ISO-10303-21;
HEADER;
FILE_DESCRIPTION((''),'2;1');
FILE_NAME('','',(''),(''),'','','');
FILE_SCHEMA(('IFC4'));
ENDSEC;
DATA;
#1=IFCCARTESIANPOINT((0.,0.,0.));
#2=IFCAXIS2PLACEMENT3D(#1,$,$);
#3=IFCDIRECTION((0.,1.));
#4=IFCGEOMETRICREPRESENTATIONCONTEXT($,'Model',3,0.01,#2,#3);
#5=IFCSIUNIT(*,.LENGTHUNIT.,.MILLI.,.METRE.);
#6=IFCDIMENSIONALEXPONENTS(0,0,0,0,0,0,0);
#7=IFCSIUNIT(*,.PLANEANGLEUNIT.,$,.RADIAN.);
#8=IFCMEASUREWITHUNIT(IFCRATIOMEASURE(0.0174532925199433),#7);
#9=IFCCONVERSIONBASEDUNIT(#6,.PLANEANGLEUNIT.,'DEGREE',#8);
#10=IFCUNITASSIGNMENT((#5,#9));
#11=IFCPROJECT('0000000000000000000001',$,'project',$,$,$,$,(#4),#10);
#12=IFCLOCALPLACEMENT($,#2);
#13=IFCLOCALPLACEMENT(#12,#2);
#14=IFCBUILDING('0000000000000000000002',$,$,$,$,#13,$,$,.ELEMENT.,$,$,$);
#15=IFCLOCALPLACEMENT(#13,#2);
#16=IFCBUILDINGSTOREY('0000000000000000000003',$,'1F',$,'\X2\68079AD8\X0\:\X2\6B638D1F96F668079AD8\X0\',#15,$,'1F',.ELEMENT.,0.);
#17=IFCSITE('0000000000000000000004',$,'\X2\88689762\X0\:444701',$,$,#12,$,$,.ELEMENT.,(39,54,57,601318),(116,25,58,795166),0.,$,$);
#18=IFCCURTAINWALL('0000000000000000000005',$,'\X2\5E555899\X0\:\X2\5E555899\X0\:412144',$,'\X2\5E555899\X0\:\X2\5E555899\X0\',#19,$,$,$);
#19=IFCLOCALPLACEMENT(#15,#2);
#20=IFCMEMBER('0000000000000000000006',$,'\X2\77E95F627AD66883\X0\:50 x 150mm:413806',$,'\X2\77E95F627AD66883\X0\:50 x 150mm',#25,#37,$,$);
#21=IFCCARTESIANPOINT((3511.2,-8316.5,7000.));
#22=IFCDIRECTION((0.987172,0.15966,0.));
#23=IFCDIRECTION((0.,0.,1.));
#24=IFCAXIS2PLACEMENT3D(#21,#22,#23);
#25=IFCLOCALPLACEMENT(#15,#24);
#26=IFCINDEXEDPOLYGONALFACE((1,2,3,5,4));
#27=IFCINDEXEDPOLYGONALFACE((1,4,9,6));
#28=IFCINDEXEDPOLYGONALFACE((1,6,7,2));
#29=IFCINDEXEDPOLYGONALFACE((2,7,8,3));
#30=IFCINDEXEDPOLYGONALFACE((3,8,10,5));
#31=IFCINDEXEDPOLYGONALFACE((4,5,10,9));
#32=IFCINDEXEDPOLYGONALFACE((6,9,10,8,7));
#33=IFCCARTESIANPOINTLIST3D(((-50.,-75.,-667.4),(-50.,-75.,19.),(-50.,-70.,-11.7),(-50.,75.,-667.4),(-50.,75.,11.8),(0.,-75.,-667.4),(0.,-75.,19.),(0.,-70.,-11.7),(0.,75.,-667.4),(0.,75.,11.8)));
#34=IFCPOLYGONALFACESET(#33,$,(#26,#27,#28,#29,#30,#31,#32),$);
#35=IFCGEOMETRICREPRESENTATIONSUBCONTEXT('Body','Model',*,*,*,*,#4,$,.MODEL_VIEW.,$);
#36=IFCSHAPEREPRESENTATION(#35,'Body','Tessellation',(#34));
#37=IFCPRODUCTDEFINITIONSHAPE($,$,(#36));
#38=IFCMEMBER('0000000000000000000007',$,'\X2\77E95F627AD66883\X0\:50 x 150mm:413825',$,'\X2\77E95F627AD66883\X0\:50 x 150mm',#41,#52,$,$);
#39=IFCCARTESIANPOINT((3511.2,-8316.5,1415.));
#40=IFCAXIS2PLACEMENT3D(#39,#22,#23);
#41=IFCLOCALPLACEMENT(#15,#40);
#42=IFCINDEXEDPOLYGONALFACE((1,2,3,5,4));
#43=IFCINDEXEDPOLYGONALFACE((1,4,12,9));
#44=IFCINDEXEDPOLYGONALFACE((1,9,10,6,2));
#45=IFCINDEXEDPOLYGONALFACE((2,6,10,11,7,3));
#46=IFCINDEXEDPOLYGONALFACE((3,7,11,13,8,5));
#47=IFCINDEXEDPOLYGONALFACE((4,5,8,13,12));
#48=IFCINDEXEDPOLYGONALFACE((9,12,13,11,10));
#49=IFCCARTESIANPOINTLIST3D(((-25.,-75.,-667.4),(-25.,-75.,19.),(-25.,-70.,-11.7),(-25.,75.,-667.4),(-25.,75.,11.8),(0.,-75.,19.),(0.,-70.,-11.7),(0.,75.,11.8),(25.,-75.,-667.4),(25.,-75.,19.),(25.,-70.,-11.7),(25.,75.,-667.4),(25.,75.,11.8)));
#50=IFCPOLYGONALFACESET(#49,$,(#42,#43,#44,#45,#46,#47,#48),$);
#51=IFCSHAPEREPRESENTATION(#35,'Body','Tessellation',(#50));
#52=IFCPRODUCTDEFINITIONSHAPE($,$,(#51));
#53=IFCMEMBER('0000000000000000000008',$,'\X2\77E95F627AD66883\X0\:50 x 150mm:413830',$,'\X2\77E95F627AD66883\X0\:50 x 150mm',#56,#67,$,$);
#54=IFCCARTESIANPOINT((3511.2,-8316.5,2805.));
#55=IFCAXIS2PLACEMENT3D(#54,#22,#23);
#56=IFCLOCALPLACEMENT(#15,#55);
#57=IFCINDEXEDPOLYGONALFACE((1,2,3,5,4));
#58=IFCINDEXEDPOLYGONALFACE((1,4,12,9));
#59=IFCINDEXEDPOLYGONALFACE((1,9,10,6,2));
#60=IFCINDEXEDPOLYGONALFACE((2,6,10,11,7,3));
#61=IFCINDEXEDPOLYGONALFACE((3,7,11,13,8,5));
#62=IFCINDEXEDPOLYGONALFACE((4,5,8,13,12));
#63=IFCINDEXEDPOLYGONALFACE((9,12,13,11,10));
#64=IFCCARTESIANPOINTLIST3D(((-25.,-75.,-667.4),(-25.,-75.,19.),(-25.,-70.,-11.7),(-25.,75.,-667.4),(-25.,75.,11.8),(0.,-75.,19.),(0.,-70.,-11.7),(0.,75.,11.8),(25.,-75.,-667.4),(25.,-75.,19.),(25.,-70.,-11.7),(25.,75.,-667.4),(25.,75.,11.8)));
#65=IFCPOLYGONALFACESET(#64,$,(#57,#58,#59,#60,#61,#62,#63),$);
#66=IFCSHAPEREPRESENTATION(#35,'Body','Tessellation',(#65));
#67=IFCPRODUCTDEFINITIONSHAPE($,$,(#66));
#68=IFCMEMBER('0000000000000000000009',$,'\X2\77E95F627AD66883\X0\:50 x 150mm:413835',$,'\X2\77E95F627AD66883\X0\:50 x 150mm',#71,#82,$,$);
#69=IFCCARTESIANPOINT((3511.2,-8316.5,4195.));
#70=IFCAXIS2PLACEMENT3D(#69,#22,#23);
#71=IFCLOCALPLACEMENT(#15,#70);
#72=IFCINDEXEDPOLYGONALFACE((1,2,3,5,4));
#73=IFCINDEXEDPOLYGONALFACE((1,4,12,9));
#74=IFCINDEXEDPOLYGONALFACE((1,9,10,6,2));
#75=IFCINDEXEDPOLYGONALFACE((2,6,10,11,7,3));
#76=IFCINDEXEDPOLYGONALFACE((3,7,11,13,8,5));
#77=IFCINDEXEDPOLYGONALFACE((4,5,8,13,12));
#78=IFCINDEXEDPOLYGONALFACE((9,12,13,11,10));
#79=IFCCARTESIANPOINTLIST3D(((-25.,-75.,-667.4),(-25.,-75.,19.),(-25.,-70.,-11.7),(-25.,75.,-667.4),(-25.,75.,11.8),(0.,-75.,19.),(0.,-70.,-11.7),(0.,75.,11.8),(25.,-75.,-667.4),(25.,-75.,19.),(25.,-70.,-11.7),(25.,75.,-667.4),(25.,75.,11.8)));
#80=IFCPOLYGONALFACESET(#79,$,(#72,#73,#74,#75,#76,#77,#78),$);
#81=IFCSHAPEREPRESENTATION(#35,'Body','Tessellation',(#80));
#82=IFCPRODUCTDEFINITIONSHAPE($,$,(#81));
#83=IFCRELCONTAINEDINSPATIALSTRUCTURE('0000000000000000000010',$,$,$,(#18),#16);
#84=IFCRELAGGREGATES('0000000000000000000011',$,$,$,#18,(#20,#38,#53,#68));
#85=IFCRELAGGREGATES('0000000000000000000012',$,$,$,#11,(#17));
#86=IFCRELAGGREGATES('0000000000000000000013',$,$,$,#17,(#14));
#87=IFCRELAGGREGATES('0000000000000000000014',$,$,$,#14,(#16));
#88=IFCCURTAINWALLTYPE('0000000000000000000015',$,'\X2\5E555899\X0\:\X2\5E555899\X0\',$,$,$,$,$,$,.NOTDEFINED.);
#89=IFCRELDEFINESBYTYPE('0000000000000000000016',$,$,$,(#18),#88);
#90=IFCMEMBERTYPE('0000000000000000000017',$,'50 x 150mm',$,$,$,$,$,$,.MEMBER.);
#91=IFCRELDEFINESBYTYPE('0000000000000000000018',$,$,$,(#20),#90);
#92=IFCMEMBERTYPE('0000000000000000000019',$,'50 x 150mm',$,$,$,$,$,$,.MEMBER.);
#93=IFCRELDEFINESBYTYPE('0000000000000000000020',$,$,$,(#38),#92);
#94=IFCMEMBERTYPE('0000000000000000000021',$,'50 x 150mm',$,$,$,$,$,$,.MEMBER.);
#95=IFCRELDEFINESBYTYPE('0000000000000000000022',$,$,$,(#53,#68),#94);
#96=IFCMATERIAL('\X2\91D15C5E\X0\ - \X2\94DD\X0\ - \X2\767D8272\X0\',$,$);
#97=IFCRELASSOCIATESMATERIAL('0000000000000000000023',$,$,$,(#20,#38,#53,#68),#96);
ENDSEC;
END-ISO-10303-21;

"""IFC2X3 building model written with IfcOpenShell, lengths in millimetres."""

from ifc_helpers import new_model, entity, si_unit, converted_unit, direction, frame, origin, origin_2d_with_axis, place, context, subcontext, project, spatial, polyline, rectangle, extrude, clip, bounded_halfspace, source, transform, mapped, material, type_object, type_shapes, element, aggregate, save


model = new_model("IFC2X3")

# Units and contexts
model_context = context("Model", 3, precision=0.01, world=origin(), true_north=direction((0.0, 1.0)))
body_context = subcontext(model_context, "Body", "Model", "MODEL_VIEW")
ifc_project = project(units=[si_unit("LENGTHUNIT", "METRE", prefix="MILLI"), converted_unit("PLANEANGLEUNIT", "DEGREE", entity("IfcRatioMeasure", 0.0174532925199433), si_unit("PLANEANGLEUNIT", "RADIAN"), dimensions=[0, 0, 0, 0, 0, 0, 0])], contexts=[model_context])

# Site, building, storey
site_placement = place(None, origin())
site = spatial("IfcSite", under=ifc_project, at=site_placement, Name="表面:444701", CompositionType="ELEMENT", RefLatitude=(39, 54, 57, 601318), RefLongitude=(116, 25, 58, 795166), RefElevation=0.0)
building_placement = place(site_placement, origin())
building = spatial("IfcBuilding", under=site, at=building_placement, CompositionType="ELEMENT")
storey_placement = place(building_placement, origin())
storey = spatial("IfcBuildingStorey", under=building, at=storey_placement, Name="1F", ObjectType="标高:正负零标高", LongName="1F", CompositionType="ELEMENT", Elevation=0.0)

# Curtain wall, members
curtain_wall_type = type_object("IfcCurtainWallType", Name="幕墙:幕墙", PredefinedType="NOTDEFINED")
curtain_wall_1_placement = place(storey_placement, origin())
curtain_wall_1 = element("IfcCurtainWall", 1, at=curtain_wall_1_placement, inside=storey, type_object=curtain_wall_type, Name="幕墙:幕墙:412144", ObjectType="幕墙:幕墙")
ifc_material_1 = material(Name="金属 - 铝 - 白色")
member_type_1 = type_object("IfcMemberType", Name="50 x 150mm", PredefinedType="MEMBER")
shared_shape_1 = source(origin(), body_context, "Body", "Clipping", [
    clip(clip(extrude(rectangle(XDim=50.0, YDim=150.0, at=origin_2d_with_axis()), frame((-25.0, 0.0, -667.4)), (0.0, 0.0, 1.0), 686.4), bounded_halfspace(frame((-1415.0, -70.0, -11.7), z_axis=(0.0, 0.987172, 0.15966), x_axis=(1.0, 0.0, 0.0)), False, frame((-25.0, 0.0, -667.4)), polyline([(-25.0, -70.0), (-25.0, -75.0), (25.0, -75.0), (25.0, -70.0), (-25.0, -70.0)]))), bounded_halfspace(frame((-1415.0, 78.0, 12.3), z_axis=(0.0, -0.15966, 0.987172), x_axis=(1.0, 0.0, 0.0)), False, frame((-25.0, 0.0, -667.4)), polyline([(25.0, 75.0), (-25.0, 75.0), (-25.0, -70.0), (25.0, -70.0), (25.0, 75.0)]))),
])
type_shapes(member_type_1, [shared_shape_1])
member_1_placement = place(storey_placement, frame((3511.2, -8316.5, 7000.0), z_axis=(0.987172, 0.15966, 0.0), x_axis=(0.0, 0.0, 1.0)))
member_1 = element("IfcMember", 2, at=member_1_placement, type_object=member_type_1, material=ifc_material_1, Name="矩形竖梃:50 x 150mm:413806", ObjectType="矩形竖梃:50 x 150mm", context=body_context, shape_type="MappedRepresentation", body=[
    mapped(shared_shape_1, transform((0.0, 0.0, 0.0), scale=1.0)),
])
member_type_2 = type_object("IfcMemberType", Name="50 x 150mm", PredefinedType="MEMBER")
shared_shape_2 = source(origin(), body_context, "Body", "Clipping", [
    clip(clip(clip(clip(extrude(rectangle(XDim=150.0, YDim=50.0, at=origin_2d_with_axis()), frame((0.0, 0.0, -667.4), z_axis=(0.0, 0.0, 1.0), x_axis=(0.0, -1.0, 0.0)), (0.0, 0.0, 1.0), 686.4), bounded_halfspace(frame((-1415.0, -70.0, -11.7), z_axis=(0.0, 0.987172, 0.15966), x_axis=(1.0, 0.0, 0.0)), False, frame((0.0, 0.0, -667.4), z_axis=(0.0, 0.0, 1.0), x_axis=(0.0, -1.0, 0.0)), polyline([(70.0, -25.0), (75.0, -25.0), (75.0, 0.0), (70.0, 0.0), (70.0, -25.0)]))), bounded_halfspace(frame((0.0, -70.0, -11.7), z_axis=(0.0, 0.987172, 0.15966), x_axis=(1.0, 0.0, 0.0)), False, frame((0.0, 0.0, -667.4), z_axis=(0.0, 0.0, 1.0), x_axis=(0.0, -1.0, 0.0)), polyline([(75.0, 0.0), (75.0, 25.0), (70.0, 25.0), (70.0, 0.0), (75.0, 0.0)]))), bounded_halfspace(frame((-1415.0, 78.0, 12.3), z_axis=(0.0, -0.15966, 0.987172), x_axis=(1.0, 0.0, 0.0)), False, frame((0.0, 0.0, -667.4), z_axis=(0.0, 0.0, 1.0), x_axis=(0.0, -1.0, 0.0)), polyline([(-75.0, 0.0), (-75.0, -25.0), (70.0, -25.0), (70.0, 0.0), (-75.0, 0.0)]))), bounded_halfspace(frame((0.0, 78.0, 12.3), z_axis=(0.0, -0.15966, 0.987172), x_axis=(1.0, 0.0, 0.0)), False, frame((0.0, 0.0, -667.4), z_axis=(0.0, 0.0, 1.0), x_axis=(0.0, -1.0, 0.0)), polyline([(-75.0, 25.0), (-75.0, 0.0), (70.0, 0.0), (70.0, 25.0), (-75.0, 25.0)]))),
])
type_shapes(member_type_2, [shared_shape_2])
member_2_placement = place(storey_placement, frame((3511.2, -8316.5, 1415.0), z_axis=(0.987172, 0.15966, 0.0), x_axis=(0.0, 0.0, 1.0)))
member_2 = element("IfcMember", 3, at=member_2_placement, type_object=member_type_2, material=ifc_material_1, Name="矩形竖梃:50 x 150mm:413825", ObjectType="矩形竖梃:50 x 150mm", context=body_context, shape_type="MappedRepresentation", body=[
    mapped(shared_shape_2, transform((0.0, 0.0, 0.0), scale=1.0)),
])
member_type_3 = type_object("IfcMemberType", Name="50 x 150mm", PredefinedType="MEMBER")
shared_shape_3 = source(origin(), body_context, "Body", "Clipping", [
    clip(clip(clip(clip(extrude(rectangle(XDim=150.0, YDim=50.0, at=origin_2d_with_axis()), frame((0.0, 0.0, -667.4), z_axis=(0.0, 0.0, 1.0), x_axis=(0.0, -1.0, 0.0)), (0.0, 0.0, 1.0), 686.4), bounded_halfspace(frame((-1390.0, -70.0, -11.7), z_axis=(0.0, 0.987172, 0.15966), x_axis=(1.0, 0.0, 0.0)), False, frame((0.0, 0.0, -667.4), z_axis=(0.0, 0.0, 1.0), x_axis=(0.0, -1.0, 0.0)), polyline([(70.0, -25.0), (75.0, -25.0), (75.0, 0.0), (70.0, 0.0), (70.0, -25.0)]))), bounded_halfspace(frame((0.0, -70.0, -11.7), z_axis=(0.0, 0.987172, 0.15966), x_axis=(1.0, 0.0, 0.0)), False, frame((0.0, 0.0, -667.4), z_axis=(0.0, 0.0, 1.0), x_axis=(0.0, -1.0, 0.0)), polyline([(75.0, 0.0), (75.0, 25.0), (70.0, 25.0), (70.0, 0.0), (75.0, 0.0)]))), bounded_halfspace(frame((-1390.0, 78.0, 12.3), z_axis=(0.0, -0.15966, 0.987172), x_axis=(1.0, 0.0, 0.0)), False, frame((0.0, 0.0, -667.4), z_axis=(0.0, 0.0, 1.0), x_axis=(0.0, -1.0, 0.0)), polyline([(-75.0, 0.0), (-75.0, -25.0), (70.0, -25.0), (70.0, 0.0), (-75.0, 0.0)]))), bounded_halfspace(frame((0.0, 78.0, 12.3), z_axis=(0.0, -0.15966, 0.987172), x_axis=(1.0, 0.0, 0.0)), False, frame((0.0, 0.0, -667.4), z_axis=(0.0, 0.0, 1.0), x_axis=(0.0, -1.0, 0.0)), polyline([(-75.0, 25.0), (-75.0, 0.0), (70.0, 0.0), (70.0, 25.0), (-75.0, 25.0)]))),
])
type_shapes(member_type_3, [shared_shape_3])
member_3_placement = place(storey_placement, frame((3511.2, -8316.5, 2805.0), z_axis=(0.987172, 0.15966, 0.0), x_axis=(0.0, 0.0, 1.0)))
member_3 = element("IfcMember", 4, at=member_3_placement, type_object=member_type_3, material=ifc_material_1, Name="矩形竖梃:50 x 150mm:413830", ObjectType="矩形竖梃:50 x 150mm", context=body_context, shape_type="MappedRepresentation", body=[
    mapped(shared_shape_3, transform((0.0, 0.0, 0.0), scale=1.0)),
])
member_4_placement = place(storey_placement, frame((3511.2, -8316.5, 4195.0), z_axis=(0.987172, 0.15966, 0.0), x_axis=(0.0, 0.0, 1.0)))
member_4 = element("IfcMember", 5, at=member_4_placement, type_object=member_type_3, material=ifc_material_1, Name="矩形竖梃:50 x 150mm:413835", ObjectType="矩形竖梃:50 x 150mm", context=body_context, shape_type="MappedRepresentation", body=[
    mapped(shared_shape_3, transform((0.0, 0.0, 0.0), scale=1.0)),
])

aggregate(curtain_wall_1, [member_1, member_2, member_3, member_4])

save(model, "model.ifc")
